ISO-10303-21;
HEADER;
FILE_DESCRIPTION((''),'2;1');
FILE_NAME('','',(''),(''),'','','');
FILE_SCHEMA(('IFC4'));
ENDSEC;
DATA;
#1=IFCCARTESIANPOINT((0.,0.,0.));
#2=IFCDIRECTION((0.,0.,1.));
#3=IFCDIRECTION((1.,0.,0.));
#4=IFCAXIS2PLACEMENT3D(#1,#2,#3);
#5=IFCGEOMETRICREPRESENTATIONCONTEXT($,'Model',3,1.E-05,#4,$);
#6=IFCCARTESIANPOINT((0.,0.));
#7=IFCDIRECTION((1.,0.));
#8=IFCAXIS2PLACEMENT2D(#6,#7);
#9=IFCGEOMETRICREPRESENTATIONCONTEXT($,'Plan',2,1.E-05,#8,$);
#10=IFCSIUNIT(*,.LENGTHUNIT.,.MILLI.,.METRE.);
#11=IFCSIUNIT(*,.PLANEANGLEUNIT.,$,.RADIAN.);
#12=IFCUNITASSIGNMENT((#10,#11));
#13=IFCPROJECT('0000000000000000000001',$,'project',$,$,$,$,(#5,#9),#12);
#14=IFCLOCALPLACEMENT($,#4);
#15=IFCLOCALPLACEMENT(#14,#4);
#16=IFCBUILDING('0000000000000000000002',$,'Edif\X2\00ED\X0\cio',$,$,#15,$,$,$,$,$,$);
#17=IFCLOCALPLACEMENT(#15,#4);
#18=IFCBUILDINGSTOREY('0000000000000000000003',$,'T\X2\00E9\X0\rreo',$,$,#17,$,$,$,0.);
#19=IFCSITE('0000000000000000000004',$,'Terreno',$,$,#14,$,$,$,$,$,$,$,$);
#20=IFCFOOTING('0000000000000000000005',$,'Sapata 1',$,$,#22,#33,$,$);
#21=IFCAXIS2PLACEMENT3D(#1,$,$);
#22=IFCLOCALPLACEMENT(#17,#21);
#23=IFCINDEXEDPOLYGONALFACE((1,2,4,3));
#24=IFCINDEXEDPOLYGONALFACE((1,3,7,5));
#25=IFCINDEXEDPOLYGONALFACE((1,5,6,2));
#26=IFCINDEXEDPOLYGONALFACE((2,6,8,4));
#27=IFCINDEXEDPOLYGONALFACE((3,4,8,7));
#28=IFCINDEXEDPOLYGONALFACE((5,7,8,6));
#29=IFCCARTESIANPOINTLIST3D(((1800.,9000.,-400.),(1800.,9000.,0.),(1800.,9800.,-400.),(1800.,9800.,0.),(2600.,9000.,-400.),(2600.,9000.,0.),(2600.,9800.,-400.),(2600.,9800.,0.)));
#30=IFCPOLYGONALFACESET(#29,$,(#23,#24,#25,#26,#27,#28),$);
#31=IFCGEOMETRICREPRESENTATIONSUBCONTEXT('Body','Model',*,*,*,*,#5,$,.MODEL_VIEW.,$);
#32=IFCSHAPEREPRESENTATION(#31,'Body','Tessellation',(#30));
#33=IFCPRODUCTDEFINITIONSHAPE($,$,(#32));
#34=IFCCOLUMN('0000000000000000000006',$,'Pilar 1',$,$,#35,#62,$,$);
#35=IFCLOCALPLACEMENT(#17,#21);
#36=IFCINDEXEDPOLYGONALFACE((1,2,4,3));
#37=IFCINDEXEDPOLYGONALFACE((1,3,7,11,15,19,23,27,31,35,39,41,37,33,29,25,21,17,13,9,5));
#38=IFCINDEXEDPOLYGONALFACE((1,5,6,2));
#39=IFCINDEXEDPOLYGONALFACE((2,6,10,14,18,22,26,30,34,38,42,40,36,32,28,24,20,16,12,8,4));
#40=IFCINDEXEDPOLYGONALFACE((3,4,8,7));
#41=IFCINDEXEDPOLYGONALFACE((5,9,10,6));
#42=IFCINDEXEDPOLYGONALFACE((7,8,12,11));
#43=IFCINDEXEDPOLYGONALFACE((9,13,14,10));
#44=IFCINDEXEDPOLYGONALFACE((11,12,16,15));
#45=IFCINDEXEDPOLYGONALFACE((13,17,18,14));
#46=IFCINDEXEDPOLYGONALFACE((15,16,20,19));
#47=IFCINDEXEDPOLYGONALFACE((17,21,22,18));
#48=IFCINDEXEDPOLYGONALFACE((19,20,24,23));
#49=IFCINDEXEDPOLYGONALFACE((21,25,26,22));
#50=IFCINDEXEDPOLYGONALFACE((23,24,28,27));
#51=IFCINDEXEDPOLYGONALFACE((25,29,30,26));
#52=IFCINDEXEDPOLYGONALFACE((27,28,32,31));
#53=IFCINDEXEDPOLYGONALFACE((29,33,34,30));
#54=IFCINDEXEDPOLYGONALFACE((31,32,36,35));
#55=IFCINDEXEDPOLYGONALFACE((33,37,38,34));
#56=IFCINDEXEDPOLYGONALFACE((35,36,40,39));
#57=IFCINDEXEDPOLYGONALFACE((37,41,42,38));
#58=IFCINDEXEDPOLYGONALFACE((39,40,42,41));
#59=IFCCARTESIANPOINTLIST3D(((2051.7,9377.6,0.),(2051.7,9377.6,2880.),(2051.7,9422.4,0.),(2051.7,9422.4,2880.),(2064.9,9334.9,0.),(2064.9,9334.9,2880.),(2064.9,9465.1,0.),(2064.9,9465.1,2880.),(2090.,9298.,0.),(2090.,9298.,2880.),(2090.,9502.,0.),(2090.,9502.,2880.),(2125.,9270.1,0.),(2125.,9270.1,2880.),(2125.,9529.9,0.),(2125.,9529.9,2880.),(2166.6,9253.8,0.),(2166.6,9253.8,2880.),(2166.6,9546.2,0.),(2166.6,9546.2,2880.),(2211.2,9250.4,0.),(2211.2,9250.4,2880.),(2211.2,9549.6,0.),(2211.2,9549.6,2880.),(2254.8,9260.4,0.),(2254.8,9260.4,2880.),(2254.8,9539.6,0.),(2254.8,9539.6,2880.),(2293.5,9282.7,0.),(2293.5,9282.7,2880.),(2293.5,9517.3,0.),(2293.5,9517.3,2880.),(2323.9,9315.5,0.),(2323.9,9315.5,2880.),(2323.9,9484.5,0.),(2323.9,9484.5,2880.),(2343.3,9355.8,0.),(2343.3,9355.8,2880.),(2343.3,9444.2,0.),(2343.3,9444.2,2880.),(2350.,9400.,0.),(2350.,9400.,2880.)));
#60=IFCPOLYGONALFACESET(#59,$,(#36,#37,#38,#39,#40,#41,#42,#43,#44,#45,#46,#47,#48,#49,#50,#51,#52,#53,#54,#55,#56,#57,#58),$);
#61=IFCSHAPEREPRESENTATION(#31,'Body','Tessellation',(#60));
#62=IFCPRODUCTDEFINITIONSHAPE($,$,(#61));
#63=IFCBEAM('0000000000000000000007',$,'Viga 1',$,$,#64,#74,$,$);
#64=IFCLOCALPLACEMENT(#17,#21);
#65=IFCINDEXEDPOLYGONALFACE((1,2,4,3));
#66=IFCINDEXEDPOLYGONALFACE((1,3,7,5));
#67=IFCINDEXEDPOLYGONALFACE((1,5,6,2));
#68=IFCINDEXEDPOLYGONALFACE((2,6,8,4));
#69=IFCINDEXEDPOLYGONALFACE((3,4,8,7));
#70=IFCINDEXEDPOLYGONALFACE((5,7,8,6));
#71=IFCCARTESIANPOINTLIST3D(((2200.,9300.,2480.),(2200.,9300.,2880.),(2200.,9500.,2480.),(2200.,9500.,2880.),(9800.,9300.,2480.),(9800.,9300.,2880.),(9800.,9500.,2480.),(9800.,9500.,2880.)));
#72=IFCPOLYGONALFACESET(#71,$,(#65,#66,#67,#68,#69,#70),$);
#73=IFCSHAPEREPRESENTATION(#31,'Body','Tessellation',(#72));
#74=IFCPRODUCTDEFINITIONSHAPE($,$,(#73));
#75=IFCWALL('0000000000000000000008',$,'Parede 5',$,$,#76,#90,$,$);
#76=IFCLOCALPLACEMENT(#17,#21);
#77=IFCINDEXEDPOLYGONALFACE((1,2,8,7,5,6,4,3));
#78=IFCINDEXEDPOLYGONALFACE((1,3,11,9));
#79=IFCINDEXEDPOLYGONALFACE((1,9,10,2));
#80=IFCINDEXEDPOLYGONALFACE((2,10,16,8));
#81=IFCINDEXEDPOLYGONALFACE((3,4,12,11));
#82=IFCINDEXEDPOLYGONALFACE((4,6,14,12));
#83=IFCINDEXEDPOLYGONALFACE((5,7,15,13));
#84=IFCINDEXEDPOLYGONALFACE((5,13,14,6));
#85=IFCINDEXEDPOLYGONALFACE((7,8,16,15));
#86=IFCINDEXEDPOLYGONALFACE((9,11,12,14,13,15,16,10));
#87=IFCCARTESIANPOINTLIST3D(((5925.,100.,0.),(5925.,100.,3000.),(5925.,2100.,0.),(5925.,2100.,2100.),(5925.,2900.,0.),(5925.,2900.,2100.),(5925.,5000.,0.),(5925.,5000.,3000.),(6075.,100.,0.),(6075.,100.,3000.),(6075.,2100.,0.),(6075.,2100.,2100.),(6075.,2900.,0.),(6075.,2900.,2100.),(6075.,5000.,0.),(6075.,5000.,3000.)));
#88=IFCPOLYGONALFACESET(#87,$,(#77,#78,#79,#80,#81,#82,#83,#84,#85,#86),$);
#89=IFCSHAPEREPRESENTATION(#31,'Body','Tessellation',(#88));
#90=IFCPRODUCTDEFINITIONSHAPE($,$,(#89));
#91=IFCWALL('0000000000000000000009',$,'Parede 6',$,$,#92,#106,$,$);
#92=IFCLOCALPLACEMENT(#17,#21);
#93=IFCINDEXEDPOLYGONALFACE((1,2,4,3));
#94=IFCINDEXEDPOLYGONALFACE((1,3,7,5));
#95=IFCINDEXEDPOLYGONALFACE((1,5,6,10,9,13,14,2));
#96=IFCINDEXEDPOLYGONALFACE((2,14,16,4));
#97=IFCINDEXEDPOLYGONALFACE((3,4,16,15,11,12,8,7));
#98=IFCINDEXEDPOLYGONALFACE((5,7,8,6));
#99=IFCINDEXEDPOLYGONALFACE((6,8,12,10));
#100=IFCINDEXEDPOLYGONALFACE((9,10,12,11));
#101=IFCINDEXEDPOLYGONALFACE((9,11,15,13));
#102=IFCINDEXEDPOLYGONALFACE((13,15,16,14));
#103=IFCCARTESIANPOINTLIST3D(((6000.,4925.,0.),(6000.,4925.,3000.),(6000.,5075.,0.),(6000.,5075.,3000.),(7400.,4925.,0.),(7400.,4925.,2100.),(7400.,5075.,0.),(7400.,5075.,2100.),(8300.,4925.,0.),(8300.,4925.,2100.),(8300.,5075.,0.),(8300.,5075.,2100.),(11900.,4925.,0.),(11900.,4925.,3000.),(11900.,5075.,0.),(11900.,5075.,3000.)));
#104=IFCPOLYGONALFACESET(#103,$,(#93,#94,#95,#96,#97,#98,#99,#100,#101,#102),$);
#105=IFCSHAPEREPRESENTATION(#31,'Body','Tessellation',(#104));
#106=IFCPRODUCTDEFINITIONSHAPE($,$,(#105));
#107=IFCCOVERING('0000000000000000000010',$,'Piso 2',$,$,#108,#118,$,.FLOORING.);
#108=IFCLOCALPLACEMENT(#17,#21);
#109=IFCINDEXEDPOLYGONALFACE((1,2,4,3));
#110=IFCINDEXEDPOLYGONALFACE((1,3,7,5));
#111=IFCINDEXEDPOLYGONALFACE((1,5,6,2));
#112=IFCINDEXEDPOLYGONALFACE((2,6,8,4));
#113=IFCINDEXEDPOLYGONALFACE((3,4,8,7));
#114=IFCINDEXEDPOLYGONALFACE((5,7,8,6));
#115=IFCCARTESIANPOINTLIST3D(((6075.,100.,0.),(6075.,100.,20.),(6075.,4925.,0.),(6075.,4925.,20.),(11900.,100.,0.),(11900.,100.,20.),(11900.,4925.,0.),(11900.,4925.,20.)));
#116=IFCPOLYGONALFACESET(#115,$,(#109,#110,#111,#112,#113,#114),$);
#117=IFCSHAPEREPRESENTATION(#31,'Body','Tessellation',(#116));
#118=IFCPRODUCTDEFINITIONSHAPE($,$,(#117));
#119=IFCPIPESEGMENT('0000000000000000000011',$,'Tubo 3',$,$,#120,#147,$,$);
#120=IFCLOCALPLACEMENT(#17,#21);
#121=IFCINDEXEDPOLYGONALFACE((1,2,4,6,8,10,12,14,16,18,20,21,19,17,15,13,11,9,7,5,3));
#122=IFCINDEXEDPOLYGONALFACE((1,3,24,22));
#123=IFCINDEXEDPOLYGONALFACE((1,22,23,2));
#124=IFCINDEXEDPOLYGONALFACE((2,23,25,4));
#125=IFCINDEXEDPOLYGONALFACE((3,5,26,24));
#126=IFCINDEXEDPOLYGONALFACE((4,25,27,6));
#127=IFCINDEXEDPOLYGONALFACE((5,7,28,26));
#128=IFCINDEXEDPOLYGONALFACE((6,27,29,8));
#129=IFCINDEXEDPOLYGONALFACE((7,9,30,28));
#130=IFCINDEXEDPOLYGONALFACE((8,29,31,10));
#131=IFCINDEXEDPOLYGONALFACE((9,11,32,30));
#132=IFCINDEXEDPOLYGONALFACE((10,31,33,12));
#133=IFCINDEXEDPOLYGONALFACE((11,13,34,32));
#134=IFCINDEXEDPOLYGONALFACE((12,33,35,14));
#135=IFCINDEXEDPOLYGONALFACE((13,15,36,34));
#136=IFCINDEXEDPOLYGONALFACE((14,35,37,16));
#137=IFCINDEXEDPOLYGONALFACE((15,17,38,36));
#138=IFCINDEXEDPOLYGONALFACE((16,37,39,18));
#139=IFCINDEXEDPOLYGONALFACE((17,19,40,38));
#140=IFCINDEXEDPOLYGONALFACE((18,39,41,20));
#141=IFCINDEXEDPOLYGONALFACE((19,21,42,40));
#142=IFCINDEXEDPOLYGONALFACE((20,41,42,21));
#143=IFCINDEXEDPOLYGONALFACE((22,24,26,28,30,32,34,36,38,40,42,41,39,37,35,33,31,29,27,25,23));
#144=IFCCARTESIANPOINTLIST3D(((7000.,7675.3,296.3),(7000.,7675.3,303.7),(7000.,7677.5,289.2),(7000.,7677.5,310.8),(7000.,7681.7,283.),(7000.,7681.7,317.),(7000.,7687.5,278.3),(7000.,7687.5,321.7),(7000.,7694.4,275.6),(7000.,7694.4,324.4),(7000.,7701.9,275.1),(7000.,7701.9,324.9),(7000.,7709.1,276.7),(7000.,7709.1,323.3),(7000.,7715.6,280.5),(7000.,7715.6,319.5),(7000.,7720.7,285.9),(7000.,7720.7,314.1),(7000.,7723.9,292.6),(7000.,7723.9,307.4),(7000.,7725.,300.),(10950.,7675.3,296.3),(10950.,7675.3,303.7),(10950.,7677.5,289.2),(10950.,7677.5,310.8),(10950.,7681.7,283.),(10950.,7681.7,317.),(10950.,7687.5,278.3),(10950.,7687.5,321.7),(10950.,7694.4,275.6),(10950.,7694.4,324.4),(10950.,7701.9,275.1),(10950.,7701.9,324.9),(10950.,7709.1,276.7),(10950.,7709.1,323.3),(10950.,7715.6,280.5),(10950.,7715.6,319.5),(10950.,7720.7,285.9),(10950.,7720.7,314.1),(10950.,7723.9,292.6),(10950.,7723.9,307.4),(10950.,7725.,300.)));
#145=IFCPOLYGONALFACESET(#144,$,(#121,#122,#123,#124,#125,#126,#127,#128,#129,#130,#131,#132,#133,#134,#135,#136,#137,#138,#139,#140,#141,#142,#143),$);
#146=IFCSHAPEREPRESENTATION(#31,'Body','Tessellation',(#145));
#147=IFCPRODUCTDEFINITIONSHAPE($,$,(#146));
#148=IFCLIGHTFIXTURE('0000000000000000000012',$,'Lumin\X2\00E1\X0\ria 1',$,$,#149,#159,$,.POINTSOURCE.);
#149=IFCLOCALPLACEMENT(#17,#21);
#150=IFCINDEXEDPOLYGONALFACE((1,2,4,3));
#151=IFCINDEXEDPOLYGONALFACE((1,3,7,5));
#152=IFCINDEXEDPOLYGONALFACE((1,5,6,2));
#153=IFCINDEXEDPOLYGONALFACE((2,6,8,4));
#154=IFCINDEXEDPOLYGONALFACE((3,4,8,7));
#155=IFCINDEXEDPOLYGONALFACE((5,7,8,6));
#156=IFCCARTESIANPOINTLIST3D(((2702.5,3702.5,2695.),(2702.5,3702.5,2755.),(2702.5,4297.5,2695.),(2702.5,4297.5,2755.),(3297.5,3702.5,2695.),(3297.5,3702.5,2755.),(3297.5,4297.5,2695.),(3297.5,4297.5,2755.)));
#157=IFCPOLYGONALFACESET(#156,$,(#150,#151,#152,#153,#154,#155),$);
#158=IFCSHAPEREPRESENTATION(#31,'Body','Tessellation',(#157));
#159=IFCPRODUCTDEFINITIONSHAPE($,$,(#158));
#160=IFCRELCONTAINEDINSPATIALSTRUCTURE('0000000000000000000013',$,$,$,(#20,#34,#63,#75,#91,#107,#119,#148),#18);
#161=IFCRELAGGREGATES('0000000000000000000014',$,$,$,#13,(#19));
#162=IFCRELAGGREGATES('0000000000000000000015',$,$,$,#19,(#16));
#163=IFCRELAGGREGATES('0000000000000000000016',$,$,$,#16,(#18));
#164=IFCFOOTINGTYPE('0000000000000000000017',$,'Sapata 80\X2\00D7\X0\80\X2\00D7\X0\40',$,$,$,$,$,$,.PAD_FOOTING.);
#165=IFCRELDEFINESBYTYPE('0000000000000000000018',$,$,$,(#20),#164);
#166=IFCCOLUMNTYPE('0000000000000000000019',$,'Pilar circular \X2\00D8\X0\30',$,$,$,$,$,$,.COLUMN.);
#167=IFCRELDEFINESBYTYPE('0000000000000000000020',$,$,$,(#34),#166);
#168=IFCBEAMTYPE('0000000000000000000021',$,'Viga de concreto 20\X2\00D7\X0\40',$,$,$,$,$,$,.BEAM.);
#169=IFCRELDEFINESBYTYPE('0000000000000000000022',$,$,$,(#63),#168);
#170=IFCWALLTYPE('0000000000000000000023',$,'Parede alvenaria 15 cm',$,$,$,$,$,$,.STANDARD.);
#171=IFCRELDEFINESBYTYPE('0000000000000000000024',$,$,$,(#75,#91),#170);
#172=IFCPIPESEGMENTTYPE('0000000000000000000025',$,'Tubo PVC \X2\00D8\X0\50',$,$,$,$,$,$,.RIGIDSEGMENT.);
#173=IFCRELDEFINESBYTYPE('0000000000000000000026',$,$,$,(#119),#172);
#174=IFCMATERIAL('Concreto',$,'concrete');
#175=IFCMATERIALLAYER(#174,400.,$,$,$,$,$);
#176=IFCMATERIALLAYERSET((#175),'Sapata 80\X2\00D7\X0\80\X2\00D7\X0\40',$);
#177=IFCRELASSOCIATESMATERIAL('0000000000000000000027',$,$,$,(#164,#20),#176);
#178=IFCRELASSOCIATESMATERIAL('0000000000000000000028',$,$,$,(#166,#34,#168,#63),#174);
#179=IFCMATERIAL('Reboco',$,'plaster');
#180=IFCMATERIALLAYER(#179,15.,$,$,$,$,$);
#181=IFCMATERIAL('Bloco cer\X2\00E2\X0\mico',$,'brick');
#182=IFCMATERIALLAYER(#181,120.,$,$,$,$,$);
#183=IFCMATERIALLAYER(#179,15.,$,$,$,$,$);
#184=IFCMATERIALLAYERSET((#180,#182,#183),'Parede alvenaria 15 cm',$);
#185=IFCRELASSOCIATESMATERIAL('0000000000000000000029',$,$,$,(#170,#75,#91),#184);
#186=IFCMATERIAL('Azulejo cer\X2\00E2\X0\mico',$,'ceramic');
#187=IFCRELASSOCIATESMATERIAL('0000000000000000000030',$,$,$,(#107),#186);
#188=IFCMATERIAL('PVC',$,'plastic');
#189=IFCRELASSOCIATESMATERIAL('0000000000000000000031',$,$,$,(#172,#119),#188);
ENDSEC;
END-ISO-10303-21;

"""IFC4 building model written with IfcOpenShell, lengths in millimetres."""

from ifc_helpers import new_model, si_unit, frame, origin, origin_with_axes, origin_2d, origin_2d_with_axis, place, context, subcontext, project, spatial, indexed_curve, rectangle, circle, outline, extrude, material, layer, layer_set, layer_usage, material_profile, profile_set, profile_usage, type_object, element, save


model = new_model("IFC4")

# Units and contexts
model_context = context("Model", 3, precision=1e-05, world=origin_with_axes())
plan_context = context("Plan", 2, precision=1e-05, world=origin_2d_with_axis())
body_context = subcontext(model_context, "Body", "Model", "MODEL_VIEW")
ifc_project = project(units=[si_unit("LENGTHUNIT", "METRE", prefix="MILLI"), si_unit("PLANEANGLEUNIT", "RADIAN")], contexts=[model_context, plan_context])

# Site, building, storey
site_placement = place(None, origin_with_axes())
site = spatial("IfcSite", under=ifc_project, at=site_placement, Name="Terreno")
building_placement = place(site_placement, origin_with_axes())
building = spatial("IfcBuilding", under=site, at=building_placement, Name="Edifício")
storey_placement = place(building_placement, origin_with_axes())
storey = spatial("IfcBuildingStorey", under=building, at=storey_placement, Name="Térreo", Elevation=0.0)

# Footing
ifc_material_1 = material(Name="Concreto", Category="concrete")
ifc_layer_1 = layer(ifc_material_1, 400.0)
ifc_layer_set_1 = layer_set([ifc_layer_1], Name="Sapata 80×80×40")
ifc_layer_usage_1 = layer_usage(ifc_layer_set_1, "AXIS3", "POSITIVE", 0.0)
footing_type = type_object("IfcFootingType", Name="Sapata 80×80×40", PredefinedType="PAD_FOOTING", material=ifc_layer_set_1)
footing_placement = place(storey_placement, frame((1800.0, 9000.0, -400.0), z_axis=(0.0, 0.0, 1.0), x_axis=(1.0, 0.0, 0.0)))
element("IfcFooting", 1, at=footing_placement, inside=storey, type_object=footing_type, material=ifc_layer_usage_1, Name="Sapata 1", context=body_context, shape_type="SweptSolid", body=[
    extrude(outline(indexed_curve([(0.0, 0.0), (800.0, 0.0), (800.0, 800.0), (0.0, 800.0)])), None, (0.0, 0.0, 1.0), 400.0),
])

# Column
ifc_material_profile_1 = material_profile(ifc_material_1, circle(Radius=150.0))
ifc_profile_set_1 = profile_set([ifc_material_profile_1], Name="Pilar circular Ø30")
ifc_profile_usage_1 = profile_usage(ifc_profile_set_1)
column_type = type_object("IfcColumnType", Name="Pilar circular Ø30", PredefinedType="COLUMN", material=ifc_profile_set_1)
column_placement = place(storey_placement, frame((2200.0, 9400.0, 0.0), z_axis=(0.0, 0.0, 1.0), x_axis=(1.0, 0.0, 0.0)))
element("IfcColumn", 2, at=column_placement, inside=storey, type_object=column_type, material=ifc_profile_usage_1, Name="Pilar 1", context=body_context, shape_type="SweptSolid", body=[
    extrude(circle(Radius=150.0), origin_with_axes(), (0.0, 0.0, 1.0), 2880.0),
])

# Beam
ifc_material_profile_2 = material_profile(ifc_material_1, rectangle(XDim=200.0, YDim=400.0))
ifc_profile_set_2 = profile_set([ifc_material_profile_2], Name="Viga de concreto 20×40")
ifc_profile_usage_2 = profile_usage(ifc_profile_set_2)
beam_type = type_object("IfcBeamType", Name="Viga de concreto 20×40", PredefinedType="BEAM", material=ifc_profile_set_2)
beam_placement = place(storey_placement, frame((2200.0, 9400.0, 2680.0), z_axis=(1.0, 0.0, 0.0), x_axis=(0.0, 1.0, 0.0)))
element("IfcBeam", 3, at=beam_placement, inside=storey, type_object=beam_type, material=ifc_profile_usage_2, Name="Viga 1", context=body_context, shape_type="SweptSolid", body=[
    extrude(rectangle(XDim=200.0, YDim=400.0), origin_with_axes(), (0.0, 0.0, 1.0), 7600.0),
])

# Walls, openings
ifc_material_2 = material(Name="Reboco", Category="plaster")
ifc_layer_2 = layer(ifc_material_2, 15.0)
ifc_material_3 = material(Name="Bloco cerâmico", Category="brick")
ifc_layer_3 = layer(ifc_material_3, 120.0)
ifc_layer_4 = layer(ifc_material_2, 15.0)
ifc_layer_set_2 = layer_set([ifc_layer_2, ifc_layer_3, ifc_layer_4], Name="Parede alvenaria 15 cm")
ifc_layer_usage_2 = layer_usage(ifc_layer_set_2, "AXIS2", "POSITIVE", -75.0)
wall_type = type_object("IfcWallType", Name="Parede alvenaria 15 cm", PredefinedType="STANDARD", material=ifc_layer_set_2)
wall_1_placement = place(storey_placement, frame((6000.0, 100.0, 0.0), z_axis=(0.0, 0.0, 1.0), x_axis=(0.0, 1.0, 0.0)))
wall_1 = element("IfcWall", 4, at=wall_1_placement, inside=storey, type_object=wall_type, material=ifc_layer_usage_2, Name="Parede 5", context=body_context, shape_type="SweptSolid", body=[
    extrude(outline(indexed_curve([(0.0, 0.0), (0.0, 150.0), (4900.0, 150.0), (4900.0, 0.0), (0.0, 0.0)], self_intersect=False)), frame((0.0, -75.0, 0.0), z_axis=(0.0, 0.0, 1.0), x_axis=(1.0, 0.0, 0.0)), (0.0, 0.0, 1.0), 3000.0),
])
opening_1_placement = place(wall_1_placement, frame((2000.0, -85.0, 0.0), z_axis=(0.0, 0.0, 1.0), x_axis=(1.0, 0.0, 0.0)))
element("IfcOpeningElement", 5, at=opening_1_placement, cuts=wall_1, context=body_context, shape_type="SweptSolid", body=[
    extrude(outline(indexed_curve([(0.0, 0.0), (0.0, 170.0), (800.0, 170.0), (800.0, 0.0), (0.0, 0.0)], self_intersect=False)), origin_with_axes(), (0.0, 0.0, 1.0), 2100.0),
])
ifc_layer_usage_3 = layer_usage(ifc_layer_set_2, "AXIS2", "POSITIVE", -75.0)
wall_2_placement = place(storey_placement, frame((6000.0, 5000.0, 0.0), z_axis=(0.0, 0.0, 1.0), x_axis=(1.0, 0.0, 0.0)))
wall_2 = element("IfcWall", 6, at=wall_2_placement, inside=storey, type_object=wall_type, material=ifc_layer_usage_3, Name="Parede 6", context=body_context, shape_type="SweptSolid", body=[
    extrude(outline(indexed_curve([(0.0, 0.0), (0.0, 150.0), (5900.0, 150.0), (5900.0, 0.0), (0.0, 0.0)], self_intersect=False)), frame((0.0, -75.0, 0.0), z_axis=(0.0, 0.0, 1.0), x_axis=(1.0, 0.0, 0.0)), (0.0, 0.0, 1.0), 3000.0),
])
opening_2_placement = place(wall_2_placement, frame((1400.0, -85.0, 0.0), z_axis=(0.0, 0.0, 1.0), x_axis=(1.0, 0.0, 0.0)))
element("IfcOpeningElement", 7, at=opening_2_placement, cuts=wall_2, context=body_context, shape_type="SweptSolid", body=[
    extrude(outline(indexed_curve([(0.0, 0.0), (0.0, 170.0), (900.0, 170.0), (900.0, 0.0), (0.0, 0.0)], self_intersect=False)), origin_with_axes(), (0.0, 0.0, 1.0), 2100.0),
])

# Covering
ifc_material_4 = material(Name="Azulejo cerâmico", Category="ceramic")
covering_placement = place(storey_placement, frame((6075.0, 100.0, 0.0), z_axis=(0.0, 0.0, 1.0), x_axis=(1.0, 0.0, 0.0)))
element("IfcCovering", 8, at=covering_placement, inside=storey, material=ifc_material_4, Name="Piso 2", PredefinedType="FLOORING", context=body_context, shape_type="SweptSolid", body=[
    extrude(outline(indexed_curve([(0.0, 0.0), (5825.0, 0.0), (5825.0, 4825.0), (0.0, 4825.0), (0.0, 0.0)], self_intersect=False)), origin(), (0.0, 0.0, 1.0), 20.0),
])

# Pipe segment
ifc_material_5 = material(Name="PVC", Category="plastic")
ifc_material_profile_3 = material_profile(ifc_material_5, circle(Radius=25.0))
ifc_profile_set_3 = profile_set([ifc_material_profile_3], Name="Tubo PVC Ø50")
ifc_profile_usage_3 = profile_usage(ifc_profile_set_3)
pipe_segment_type = type_object("IfcPipeSegmentType", Name="Tubo PVC Ø50", PredefinedType="RIGIDSEGMENT", material=ifc_profile_set_3)
pipe_segment_placement = place(storey_placement, frame((7000.0, 7700.0, 300.0), z_axis=(1.0, 0.0, 0.0), x_axis=(0.0, 1.0, 0.0)))
element("IfcPipeSegment", 9, at=pipe_segment_placement, inside=storey, type_object=pipe_segment_type, material=ifc_profile_usage_3, Name="Tubo 3", context=body_context, shape_type="SweptSolid", body=[
    extrude(circle(Radius=25.0), origin_with_axes(), (0.0, 0.0, 1.0), 3950.0),
])

# Light fixture
light_fixture_1_placement = place(storey_placement, frame((3000.0, 4000.0, 2695.0), z_axis=(0.0, 0.0, 1.0), x_axis=(1.0, 0.0, 0.0)))
element("IfcLightFixture", 10, at=light_fixture_1_placement, inside=storey, Name="Luminária 1", PredefinedType="POINTSOURCE", context=body_context, shape_type="SweptSolid", body=[
    extrude(rectangle(XDim=595.0, YDim=595.0, at=origin_2d()), origin(), (0.0, 0.0, 1.0), 60.0),
])

save(model, "model.ifc")
